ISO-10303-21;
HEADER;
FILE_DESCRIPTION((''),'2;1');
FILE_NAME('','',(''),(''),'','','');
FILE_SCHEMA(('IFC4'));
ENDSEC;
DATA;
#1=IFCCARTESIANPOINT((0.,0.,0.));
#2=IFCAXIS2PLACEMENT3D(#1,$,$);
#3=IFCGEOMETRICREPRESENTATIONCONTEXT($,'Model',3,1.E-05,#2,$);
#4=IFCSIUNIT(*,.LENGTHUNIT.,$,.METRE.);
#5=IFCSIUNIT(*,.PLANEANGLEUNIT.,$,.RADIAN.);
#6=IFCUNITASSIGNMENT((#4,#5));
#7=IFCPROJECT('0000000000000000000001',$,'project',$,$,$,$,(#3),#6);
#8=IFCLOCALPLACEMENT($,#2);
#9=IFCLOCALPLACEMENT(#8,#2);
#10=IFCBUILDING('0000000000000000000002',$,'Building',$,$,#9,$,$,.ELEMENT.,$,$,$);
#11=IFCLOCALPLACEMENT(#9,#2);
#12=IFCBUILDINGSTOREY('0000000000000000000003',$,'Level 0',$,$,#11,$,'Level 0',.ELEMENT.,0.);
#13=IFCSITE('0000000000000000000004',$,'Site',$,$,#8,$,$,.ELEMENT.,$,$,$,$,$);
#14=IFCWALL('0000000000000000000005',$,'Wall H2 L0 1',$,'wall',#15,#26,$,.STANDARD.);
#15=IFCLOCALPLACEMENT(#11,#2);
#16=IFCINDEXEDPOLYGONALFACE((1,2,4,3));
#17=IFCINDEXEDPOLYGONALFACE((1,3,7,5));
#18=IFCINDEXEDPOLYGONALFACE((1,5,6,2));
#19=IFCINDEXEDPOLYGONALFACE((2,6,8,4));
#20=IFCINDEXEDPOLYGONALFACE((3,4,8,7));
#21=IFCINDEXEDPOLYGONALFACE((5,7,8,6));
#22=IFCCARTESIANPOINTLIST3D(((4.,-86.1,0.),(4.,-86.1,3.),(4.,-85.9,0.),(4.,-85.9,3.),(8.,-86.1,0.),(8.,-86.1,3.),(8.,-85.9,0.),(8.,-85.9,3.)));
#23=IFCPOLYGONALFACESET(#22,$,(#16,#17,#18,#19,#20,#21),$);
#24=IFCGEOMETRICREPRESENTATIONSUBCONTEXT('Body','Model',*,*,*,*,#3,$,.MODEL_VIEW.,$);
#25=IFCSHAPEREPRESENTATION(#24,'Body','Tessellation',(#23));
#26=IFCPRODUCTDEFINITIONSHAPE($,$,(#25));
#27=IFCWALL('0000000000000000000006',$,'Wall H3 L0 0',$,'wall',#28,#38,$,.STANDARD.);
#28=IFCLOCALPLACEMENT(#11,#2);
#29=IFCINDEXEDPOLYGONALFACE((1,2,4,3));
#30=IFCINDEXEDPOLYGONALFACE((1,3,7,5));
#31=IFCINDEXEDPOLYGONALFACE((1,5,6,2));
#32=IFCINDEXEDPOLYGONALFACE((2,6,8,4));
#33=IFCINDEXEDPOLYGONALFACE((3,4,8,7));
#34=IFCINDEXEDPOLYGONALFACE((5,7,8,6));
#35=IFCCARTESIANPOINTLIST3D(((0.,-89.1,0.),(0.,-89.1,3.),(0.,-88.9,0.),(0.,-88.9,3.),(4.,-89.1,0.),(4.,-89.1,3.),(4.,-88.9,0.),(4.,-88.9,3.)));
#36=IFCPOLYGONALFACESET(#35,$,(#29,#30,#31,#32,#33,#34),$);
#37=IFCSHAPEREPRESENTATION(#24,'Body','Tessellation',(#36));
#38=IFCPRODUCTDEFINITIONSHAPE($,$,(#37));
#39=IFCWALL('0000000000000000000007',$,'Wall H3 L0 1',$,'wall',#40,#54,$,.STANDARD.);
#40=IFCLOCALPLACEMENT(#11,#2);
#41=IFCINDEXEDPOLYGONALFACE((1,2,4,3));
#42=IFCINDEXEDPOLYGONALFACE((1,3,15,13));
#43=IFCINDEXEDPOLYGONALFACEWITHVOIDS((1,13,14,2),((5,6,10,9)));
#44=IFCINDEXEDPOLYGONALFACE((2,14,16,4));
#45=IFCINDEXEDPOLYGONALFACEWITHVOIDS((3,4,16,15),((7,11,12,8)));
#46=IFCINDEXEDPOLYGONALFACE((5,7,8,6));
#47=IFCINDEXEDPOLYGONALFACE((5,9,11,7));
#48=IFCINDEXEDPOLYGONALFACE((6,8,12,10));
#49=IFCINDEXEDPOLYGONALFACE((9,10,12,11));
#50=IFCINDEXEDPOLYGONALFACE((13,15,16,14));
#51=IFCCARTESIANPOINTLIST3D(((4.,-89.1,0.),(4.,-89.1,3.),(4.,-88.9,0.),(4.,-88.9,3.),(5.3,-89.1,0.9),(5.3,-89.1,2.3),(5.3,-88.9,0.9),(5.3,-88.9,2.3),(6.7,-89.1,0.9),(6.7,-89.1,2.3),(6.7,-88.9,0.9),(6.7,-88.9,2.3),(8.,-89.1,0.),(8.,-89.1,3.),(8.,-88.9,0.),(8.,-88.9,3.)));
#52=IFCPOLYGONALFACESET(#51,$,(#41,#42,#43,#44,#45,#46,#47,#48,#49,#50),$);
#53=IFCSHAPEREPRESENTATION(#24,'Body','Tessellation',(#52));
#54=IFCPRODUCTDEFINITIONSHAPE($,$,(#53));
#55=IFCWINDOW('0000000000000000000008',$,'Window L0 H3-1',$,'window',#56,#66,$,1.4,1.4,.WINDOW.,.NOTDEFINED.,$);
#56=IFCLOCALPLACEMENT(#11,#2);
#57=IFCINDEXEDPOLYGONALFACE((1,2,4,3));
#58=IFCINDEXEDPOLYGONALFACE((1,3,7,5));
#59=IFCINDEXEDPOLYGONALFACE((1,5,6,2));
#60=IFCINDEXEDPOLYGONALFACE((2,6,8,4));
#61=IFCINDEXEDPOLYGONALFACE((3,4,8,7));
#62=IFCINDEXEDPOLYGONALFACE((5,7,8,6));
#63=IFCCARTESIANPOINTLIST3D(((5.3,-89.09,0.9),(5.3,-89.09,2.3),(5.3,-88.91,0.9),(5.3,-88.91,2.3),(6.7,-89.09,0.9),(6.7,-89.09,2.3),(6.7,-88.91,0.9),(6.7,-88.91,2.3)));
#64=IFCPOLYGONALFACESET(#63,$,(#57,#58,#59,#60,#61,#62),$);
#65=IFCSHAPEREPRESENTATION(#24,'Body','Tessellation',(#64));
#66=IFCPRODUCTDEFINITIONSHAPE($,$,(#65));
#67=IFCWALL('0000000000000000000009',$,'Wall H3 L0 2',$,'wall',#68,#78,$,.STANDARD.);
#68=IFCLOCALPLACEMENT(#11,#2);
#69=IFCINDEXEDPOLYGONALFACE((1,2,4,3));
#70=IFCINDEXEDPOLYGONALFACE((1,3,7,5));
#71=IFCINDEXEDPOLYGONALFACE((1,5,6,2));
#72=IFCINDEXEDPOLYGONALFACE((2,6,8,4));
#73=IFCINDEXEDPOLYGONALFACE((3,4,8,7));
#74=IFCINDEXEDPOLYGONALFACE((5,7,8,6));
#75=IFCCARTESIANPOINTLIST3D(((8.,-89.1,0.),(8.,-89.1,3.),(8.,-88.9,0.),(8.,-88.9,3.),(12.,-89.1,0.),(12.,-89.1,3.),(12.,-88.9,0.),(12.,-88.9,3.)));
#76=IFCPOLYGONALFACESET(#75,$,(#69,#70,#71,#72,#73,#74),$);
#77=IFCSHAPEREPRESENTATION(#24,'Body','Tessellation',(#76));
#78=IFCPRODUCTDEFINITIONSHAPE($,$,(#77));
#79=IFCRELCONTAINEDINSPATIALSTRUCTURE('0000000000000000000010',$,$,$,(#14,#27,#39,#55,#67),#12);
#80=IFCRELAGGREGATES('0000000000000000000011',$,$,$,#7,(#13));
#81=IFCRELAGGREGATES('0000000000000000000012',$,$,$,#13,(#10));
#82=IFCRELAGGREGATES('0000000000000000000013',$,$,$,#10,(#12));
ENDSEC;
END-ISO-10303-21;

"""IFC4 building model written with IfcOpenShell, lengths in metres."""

from ifc_helpers import new_model, si_unit, frame, frame_2d, origin, origin_2d, place, context, subcontext, project, spatial, rectangle, extrude, element, fill, save


model = new_model("IFC4")

# Units and contexts
model_context = context("Model", 3, precision=1e-05, world=origin())
body_context = subcontext(model_context, "Body", "Model", "MODEL_VIEW")
ifc_project = project(units=[si_unit("LENGTHUNIT", "METRE"), si_unit("PLANEANGLEUNIT", "RADIAN")], contexts=[model_context])

# Site, building, storey
site_placement = place(None, origin())
site = spatial("IfcSite", under=ifc_project, at=site_placement, Name="Site", CompositionType="ELEMENT")
building_placement = place(site_placement, origin())
building = spatial("IfcBuilding", under=site, at=building_placement, Name="Building", CompositionType="ELEMENT")
storey_placement = place(building_placement, origin())
storey = spatial("IfcBuildingStorey", under=building, at=storey_placement, Name="Level 0", LongName="Level 0", CompositionType="ELEMENT", Elevation=0.0)

# Walls
for number, where, z_axis, x_axis, name in (
    (1, (4.0, -86.0, 0.0), (0.0, 0.0, 1.0), (1.0, 0.0, 0.0), "Wall H2 L0 1"),
    (2, (0.0, -89.0, 0.0), (0.0, 0.0, 1.0), (1.0, 0.0, 0.0), "Wall H3 L0 0"),
):
    element("IfcWall", number, at=place(storey_placement, frame(where, z_axis=z_axis, x_axis=x_axis)), inside=storey, Name=name, ObjectType="wall", PredefinedType="STANDARD", context=body_context, shape_type="SweptSolid", body=[
        extrude(rectangle(XDim=4.0, YDim=0.2, at=frame_2d((2.0, 0.0))), origin(), (0.0, 0.0, 1.0), 3.0),
    ])

# Wall, opening, window
wall_1_placement = place(storey_placement, frame((4.0, -89.0, 0.0), z_axis=(0.0, 0.0, 1.0), x_axis=(1.0, 0.0, 0.0)))
wall_1 = element("IfcWall", 3, at=wall_1_placement, inside=storey, Name="Wall H3 L0 1", ObjectType="wall", PredefinedType="STANDARD", context=body_context, shape_type="SweptSolid", body=[
    extrude(rectangle(XDim=4.0, YDim=0.2, at=frame_2d((2.0, 0.0))), origin(), (0.0, 0.0, 1.0), 3.0),
])
opening_1_placement = place(storey_placement, frame((6.0, -89.0, 0.9), z_axis=(0.0, 0.0, 1.0), x_axis=(1.0, 0.0, 0.0)))
opening_1 = element("IfcOpeningElement", 4, at=opening_1_placement, cuts=wall_1, ObjectType="Opening", PredefinedType="OPENING", context=body_context, shape_type="SweptSolid", body=[
    extrude(rectangle(XDim=1.4, YDim=0.22, at=origin_2d()), origin(), (0.0, 0.0, 1.0), 1.4),
])
window_1_placement = place(storey_placement, frame((6.0, -89.0, 0.9), z_axis=(0.0, 0.0, 1.0), x_axis=(1.0, 0.0, 0.0)))
window_1 = element("IfcWindow", 5, at=window_1_placement, inside=storey, Name="Window L0 H3-1", ObjectType="window", OverallHeight=1.4, OverallWidth=1.4, PartitioningType="NOTDEFINED", PredefinedType="WINDOW", context=body_context, shape_type="SweptSolid", body=[
    extrude(rectangle(XDim=1.4, YDim=0.18, at=origin_2d()), origin(), (0.0, 0.0, 1.0), 1.4),
])
fill(opening_1, window_1)

# Wall
wall_2_placement = place(storey_placement, frame((8.0, -89.0, 0.0), z_axis=(0.0, 0.0, 1.0), x_axis=(1.0, 0.0, 0.0)))
element("IfcWall", 6, at=wall_2_placement, inside=storey, Name="Wall H3 L0 2", ObjectType="wall", PredefinedType="STANDARD", context=body_context, shape_type="SweptSolid", body=[
    extrude(rectangle(XDim=4.0, YDim=0.2, at=frame_2d((2.0, 0.0))), origin(), (0.0, 0.0, 1.0), 3.0),
])

save(model, "model.ifc")
